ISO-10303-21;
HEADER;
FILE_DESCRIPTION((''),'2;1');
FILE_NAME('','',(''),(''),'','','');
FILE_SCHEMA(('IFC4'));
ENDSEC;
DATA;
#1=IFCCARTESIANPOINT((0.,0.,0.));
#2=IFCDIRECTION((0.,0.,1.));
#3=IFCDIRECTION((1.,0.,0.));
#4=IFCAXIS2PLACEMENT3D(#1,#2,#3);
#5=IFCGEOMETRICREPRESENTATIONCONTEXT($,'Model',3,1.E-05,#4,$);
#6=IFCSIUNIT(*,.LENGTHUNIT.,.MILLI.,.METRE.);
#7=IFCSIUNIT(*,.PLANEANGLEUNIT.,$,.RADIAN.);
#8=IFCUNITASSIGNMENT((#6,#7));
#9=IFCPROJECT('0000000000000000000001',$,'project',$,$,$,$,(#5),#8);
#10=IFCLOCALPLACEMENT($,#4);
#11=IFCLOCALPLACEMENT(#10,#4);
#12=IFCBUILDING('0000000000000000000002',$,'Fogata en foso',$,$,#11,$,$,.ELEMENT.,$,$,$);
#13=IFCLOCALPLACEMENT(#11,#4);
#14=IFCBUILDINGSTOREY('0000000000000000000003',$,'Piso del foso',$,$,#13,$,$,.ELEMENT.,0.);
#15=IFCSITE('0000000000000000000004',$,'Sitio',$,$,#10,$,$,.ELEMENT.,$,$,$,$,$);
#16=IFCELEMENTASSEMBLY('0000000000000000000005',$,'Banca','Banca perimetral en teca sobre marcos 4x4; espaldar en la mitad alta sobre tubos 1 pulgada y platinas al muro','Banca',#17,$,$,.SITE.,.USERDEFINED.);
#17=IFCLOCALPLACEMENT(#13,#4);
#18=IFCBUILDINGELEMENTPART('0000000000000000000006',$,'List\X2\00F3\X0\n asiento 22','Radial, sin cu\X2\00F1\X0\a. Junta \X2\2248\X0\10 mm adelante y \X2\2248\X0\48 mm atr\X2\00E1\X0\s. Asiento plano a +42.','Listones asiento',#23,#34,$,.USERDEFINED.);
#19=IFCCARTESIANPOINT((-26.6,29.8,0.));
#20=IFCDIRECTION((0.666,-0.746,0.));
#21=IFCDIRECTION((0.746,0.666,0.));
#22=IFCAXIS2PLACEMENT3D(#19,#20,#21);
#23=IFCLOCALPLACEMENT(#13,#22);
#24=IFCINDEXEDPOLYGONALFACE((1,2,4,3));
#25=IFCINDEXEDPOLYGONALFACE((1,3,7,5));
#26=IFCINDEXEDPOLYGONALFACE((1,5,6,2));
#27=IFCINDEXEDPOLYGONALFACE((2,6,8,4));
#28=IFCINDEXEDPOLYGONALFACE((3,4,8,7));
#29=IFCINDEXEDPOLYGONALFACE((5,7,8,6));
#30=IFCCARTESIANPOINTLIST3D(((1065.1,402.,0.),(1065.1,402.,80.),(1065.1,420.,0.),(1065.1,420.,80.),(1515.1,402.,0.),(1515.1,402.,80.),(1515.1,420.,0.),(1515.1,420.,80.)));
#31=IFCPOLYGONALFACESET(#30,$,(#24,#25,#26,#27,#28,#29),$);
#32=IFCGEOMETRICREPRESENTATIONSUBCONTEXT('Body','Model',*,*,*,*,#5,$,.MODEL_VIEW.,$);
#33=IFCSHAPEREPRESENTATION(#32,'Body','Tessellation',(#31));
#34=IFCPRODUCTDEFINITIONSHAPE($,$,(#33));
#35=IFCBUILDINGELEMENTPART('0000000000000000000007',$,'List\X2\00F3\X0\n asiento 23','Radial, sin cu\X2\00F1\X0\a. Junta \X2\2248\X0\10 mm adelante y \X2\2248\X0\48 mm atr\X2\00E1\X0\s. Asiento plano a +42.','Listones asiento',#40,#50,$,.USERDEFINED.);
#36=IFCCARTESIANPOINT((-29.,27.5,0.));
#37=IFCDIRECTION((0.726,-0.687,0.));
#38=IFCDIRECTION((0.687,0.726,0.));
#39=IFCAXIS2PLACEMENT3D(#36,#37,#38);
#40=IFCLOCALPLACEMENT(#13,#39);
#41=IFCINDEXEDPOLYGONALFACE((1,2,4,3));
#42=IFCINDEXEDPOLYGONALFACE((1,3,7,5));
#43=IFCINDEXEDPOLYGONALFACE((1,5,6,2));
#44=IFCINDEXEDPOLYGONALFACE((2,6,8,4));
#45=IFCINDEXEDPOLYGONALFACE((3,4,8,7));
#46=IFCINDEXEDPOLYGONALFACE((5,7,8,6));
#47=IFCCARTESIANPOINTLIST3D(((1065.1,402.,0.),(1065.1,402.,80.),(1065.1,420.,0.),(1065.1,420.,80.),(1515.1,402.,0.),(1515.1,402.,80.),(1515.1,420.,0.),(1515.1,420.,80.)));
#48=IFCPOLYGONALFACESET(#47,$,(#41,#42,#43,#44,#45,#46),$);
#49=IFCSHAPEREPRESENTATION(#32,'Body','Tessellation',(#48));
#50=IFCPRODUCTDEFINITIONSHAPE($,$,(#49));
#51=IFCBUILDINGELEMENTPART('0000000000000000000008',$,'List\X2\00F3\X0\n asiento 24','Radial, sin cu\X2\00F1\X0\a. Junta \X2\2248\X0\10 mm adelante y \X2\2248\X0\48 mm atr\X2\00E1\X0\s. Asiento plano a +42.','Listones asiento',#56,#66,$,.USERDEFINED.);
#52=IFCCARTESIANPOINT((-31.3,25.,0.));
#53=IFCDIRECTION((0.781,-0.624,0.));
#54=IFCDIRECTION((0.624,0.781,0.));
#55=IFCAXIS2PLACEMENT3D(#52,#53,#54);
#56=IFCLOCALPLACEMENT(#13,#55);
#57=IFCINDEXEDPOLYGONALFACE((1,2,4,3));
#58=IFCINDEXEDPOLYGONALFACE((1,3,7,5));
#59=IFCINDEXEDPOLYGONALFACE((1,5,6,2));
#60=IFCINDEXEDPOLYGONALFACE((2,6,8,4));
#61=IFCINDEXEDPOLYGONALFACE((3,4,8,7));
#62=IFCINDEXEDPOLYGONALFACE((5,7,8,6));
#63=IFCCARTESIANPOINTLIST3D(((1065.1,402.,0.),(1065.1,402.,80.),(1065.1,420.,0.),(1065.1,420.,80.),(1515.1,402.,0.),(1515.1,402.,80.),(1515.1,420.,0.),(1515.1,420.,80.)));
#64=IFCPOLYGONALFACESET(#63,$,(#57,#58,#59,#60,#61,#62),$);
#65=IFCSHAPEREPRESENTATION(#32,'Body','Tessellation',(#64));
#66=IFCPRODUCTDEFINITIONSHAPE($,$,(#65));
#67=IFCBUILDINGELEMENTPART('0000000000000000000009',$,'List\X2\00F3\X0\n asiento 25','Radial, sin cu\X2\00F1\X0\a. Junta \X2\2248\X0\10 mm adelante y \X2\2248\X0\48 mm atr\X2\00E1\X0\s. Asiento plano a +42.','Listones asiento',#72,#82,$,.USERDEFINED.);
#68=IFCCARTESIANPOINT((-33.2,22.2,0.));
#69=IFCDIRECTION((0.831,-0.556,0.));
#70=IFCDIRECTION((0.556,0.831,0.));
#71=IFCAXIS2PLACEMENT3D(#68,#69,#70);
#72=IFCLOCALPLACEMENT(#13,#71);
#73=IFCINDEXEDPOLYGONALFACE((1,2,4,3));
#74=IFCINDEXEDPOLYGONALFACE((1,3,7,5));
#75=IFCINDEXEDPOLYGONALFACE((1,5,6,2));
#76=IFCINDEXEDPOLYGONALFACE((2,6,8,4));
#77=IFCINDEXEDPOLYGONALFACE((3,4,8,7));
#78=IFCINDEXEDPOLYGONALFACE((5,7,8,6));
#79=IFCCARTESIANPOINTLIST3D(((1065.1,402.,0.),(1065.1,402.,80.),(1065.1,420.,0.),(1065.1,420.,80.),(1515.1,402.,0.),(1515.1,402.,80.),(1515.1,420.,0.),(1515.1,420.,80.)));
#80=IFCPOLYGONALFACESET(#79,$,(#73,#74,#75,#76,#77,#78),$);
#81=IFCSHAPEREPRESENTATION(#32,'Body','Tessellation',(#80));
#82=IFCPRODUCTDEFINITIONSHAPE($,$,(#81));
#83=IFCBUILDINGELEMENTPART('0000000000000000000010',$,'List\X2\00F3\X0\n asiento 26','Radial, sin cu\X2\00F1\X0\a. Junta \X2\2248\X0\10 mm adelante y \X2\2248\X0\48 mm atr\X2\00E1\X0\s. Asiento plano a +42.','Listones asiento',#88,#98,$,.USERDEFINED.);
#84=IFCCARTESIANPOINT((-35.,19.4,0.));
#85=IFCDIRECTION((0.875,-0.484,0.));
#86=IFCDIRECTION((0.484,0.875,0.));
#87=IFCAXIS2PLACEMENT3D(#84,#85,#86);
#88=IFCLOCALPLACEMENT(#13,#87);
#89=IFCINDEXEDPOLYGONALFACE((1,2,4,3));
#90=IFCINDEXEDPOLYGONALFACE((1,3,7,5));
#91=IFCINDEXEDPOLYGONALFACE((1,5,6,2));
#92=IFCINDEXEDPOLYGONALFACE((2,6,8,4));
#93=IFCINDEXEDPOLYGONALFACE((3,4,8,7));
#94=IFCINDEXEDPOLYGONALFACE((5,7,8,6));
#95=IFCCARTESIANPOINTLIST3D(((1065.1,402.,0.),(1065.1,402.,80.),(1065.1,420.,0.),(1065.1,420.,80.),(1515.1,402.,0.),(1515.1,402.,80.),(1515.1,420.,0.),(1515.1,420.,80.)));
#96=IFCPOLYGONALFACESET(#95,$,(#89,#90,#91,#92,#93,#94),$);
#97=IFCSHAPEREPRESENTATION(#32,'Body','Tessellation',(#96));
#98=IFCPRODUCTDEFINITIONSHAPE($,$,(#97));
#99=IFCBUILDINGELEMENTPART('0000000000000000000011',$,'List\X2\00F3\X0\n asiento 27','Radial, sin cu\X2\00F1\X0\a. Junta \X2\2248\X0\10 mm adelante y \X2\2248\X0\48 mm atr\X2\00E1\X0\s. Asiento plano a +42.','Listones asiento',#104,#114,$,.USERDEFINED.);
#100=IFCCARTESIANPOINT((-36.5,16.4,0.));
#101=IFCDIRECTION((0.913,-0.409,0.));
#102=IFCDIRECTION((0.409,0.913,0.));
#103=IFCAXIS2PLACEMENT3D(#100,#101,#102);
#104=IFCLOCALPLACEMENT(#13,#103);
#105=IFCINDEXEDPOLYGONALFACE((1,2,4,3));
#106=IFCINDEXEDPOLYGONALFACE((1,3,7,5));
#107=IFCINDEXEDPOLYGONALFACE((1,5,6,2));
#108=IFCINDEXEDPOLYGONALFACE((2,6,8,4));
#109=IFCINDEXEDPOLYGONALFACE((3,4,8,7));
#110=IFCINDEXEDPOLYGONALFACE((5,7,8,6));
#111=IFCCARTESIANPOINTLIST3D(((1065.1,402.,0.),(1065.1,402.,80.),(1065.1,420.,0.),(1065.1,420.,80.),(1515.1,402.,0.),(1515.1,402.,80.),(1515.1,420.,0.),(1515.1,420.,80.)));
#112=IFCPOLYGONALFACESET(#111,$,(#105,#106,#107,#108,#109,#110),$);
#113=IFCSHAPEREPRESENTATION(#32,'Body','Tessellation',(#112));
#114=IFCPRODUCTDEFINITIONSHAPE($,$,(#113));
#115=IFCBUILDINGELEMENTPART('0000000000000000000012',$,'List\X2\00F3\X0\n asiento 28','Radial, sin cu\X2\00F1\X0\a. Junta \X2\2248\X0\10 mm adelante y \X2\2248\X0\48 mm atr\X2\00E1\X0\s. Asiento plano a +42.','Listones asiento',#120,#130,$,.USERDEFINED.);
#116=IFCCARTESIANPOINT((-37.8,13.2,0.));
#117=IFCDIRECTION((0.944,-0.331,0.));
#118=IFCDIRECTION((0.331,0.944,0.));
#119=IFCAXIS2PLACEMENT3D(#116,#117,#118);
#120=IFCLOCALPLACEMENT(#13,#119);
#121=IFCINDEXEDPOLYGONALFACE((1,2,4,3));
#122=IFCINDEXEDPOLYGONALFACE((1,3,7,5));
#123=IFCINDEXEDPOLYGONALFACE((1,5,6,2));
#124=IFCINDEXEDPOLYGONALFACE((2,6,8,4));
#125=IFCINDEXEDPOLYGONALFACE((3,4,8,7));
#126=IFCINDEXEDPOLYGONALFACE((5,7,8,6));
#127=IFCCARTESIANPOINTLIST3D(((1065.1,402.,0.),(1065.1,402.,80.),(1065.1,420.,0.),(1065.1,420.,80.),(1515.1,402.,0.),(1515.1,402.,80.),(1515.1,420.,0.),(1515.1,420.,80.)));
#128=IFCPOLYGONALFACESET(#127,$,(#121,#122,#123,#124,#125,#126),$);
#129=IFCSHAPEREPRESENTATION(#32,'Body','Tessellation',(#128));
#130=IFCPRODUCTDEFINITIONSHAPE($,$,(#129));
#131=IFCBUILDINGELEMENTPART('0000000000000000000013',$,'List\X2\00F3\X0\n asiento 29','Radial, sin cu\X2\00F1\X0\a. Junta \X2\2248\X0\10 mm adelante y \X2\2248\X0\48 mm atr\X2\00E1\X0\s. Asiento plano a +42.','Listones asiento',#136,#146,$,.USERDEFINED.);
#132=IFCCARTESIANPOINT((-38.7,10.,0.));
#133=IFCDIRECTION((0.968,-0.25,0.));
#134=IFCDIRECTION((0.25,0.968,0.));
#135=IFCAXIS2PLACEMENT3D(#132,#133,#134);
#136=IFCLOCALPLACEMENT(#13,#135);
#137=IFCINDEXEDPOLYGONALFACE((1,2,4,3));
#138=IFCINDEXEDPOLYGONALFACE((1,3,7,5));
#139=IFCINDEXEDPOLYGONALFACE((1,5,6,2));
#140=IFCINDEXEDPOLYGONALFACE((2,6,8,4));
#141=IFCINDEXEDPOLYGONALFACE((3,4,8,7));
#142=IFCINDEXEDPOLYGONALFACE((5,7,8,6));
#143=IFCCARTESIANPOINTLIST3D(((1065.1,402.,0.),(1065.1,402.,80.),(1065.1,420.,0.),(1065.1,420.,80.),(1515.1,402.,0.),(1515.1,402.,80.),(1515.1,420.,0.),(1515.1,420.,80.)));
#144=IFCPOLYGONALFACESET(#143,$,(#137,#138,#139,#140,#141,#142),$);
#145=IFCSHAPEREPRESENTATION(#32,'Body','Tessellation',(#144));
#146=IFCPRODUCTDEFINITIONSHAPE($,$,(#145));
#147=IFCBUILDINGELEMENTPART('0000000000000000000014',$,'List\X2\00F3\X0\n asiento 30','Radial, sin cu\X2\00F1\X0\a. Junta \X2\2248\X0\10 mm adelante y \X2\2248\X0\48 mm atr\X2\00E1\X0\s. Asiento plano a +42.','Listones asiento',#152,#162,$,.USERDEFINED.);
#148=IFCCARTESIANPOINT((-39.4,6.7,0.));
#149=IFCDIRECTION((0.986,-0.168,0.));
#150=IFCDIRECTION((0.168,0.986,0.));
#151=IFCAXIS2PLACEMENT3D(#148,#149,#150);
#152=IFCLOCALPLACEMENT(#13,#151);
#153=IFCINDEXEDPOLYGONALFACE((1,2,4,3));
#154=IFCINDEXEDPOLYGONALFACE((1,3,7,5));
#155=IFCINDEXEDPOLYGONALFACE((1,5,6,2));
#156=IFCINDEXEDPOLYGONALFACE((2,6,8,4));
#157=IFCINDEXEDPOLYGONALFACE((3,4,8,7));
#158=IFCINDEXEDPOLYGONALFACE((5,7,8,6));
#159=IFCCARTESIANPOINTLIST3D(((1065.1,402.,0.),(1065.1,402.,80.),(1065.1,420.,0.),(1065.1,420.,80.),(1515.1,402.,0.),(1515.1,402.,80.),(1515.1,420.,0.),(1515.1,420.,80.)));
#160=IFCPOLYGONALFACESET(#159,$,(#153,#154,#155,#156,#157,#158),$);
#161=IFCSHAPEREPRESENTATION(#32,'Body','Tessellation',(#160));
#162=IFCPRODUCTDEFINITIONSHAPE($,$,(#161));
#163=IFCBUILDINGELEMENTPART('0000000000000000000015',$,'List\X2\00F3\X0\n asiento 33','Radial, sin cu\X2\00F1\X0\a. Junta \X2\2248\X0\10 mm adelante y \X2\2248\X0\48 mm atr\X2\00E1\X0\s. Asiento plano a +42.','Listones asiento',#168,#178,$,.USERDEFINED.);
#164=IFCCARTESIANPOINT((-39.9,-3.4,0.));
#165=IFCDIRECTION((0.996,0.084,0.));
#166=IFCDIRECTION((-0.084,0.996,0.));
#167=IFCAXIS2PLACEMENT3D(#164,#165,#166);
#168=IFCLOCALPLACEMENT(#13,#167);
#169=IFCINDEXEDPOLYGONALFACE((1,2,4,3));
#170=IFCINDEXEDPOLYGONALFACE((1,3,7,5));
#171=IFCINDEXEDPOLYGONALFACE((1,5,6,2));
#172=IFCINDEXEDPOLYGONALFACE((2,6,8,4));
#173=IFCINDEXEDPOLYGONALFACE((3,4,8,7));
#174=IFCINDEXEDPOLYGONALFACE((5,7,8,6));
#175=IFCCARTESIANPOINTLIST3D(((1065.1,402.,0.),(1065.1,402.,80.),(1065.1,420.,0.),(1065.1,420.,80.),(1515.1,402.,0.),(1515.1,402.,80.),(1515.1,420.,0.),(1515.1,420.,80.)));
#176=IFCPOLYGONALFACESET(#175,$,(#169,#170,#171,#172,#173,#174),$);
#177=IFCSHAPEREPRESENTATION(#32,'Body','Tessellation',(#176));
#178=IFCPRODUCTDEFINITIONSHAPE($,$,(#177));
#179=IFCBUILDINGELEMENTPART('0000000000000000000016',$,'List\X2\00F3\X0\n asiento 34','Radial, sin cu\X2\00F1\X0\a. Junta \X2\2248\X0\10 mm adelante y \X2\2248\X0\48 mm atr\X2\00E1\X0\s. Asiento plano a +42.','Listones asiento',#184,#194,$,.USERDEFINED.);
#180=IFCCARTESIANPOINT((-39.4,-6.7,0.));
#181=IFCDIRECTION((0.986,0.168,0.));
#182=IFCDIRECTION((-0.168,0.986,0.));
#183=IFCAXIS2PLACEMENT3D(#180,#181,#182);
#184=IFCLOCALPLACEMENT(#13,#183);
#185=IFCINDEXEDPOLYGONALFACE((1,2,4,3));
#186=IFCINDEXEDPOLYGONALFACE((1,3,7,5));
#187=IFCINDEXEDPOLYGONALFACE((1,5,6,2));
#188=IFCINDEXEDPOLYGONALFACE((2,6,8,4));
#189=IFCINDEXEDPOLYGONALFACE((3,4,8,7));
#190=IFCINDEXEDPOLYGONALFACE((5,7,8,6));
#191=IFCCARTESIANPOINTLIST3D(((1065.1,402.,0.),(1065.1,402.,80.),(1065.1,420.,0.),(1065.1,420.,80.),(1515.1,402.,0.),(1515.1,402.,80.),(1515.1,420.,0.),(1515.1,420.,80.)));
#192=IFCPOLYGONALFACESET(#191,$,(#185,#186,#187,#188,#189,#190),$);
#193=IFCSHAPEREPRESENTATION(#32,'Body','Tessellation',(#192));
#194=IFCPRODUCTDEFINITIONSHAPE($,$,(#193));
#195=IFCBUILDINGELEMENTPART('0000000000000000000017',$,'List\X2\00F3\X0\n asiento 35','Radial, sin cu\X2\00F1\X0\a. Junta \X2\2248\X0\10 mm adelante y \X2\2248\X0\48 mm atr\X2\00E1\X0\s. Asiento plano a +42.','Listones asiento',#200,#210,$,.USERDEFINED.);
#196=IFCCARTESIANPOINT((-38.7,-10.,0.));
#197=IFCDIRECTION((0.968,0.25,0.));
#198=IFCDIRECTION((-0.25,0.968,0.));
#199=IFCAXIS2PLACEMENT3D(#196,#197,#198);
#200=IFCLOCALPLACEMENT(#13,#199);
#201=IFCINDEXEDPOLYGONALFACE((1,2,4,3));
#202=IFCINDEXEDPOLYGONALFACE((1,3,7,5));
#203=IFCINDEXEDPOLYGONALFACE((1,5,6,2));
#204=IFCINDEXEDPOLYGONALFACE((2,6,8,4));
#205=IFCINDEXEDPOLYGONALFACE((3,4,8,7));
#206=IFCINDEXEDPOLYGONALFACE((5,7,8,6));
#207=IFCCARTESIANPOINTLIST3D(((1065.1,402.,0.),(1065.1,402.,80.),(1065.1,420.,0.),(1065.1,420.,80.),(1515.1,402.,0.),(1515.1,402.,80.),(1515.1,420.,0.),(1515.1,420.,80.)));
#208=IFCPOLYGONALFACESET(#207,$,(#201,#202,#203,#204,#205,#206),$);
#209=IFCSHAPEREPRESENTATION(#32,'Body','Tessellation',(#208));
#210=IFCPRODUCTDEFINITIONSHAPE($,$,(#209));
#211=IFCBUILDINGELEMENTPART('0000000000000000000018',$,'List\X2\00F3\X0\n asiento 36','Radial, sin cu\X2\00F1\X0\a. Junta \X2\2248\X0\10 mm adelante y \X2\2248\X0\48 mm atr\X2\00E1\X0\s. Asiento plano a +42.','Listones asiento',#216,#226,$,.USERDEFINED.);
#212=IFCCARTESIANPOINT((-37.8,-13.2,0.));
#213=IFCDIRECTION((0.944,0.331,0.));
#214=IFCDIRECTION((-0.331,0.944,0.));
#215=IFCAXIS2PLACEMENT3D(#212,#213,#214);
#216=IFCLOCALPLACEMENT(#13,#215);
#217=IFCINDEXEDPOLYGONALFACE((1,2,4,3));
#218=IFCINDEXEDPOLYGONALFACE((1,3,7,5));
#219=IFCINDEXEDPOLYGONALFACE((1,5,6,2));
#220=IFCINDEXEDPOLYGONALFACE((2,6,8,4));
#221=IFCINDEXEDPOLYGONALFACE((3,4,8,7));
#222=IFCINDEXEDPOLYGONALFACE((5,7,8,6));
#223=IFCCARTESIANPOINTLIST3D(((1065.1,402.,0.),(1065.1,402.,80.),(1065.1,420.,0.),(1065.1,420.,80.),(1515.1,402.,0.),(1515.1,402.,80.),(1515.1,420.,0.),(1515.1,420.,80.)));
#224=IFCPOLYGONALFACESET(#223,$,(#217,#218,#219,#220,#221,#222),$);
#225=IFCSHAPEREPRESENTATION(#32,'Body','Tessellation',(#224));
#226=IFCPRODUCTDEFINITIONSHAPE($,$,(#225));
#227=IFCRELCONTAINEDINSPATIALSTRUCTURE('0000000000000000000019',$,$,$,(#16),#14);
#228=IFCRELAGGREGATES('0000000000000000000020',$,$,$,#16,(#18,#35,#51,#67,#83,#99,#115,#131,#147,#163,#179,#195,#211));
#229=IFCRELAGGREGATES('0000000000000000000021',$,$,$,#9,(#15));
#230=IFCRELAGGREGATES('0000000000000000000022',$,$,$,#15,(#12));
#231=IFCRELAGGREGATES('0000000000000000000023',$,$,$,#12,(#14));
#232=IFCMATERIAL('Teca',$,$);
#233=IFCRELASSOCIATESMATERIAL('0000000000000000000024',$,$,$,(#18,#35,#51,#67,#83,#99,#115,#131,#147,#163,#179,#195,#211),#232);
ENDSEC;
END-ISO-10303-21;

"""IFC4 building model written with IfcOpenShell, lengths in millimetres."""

from ifc_helpers import new_model, si_unit, frame, origin_with_axes, place, context, subcontext, project, spatial, polyline, outline, extrude, material, element, aggregate, save


model = new_model("IFC4")

# Units and contexts
model_context = context("Model", 3, precision=1e-05, world=origin_with_axes())
body_context = subcontext(model_context, "Body", "Model", "MODEL_VIEW")
ifc_project = project(units=[si_unit("LENGTHUNIT", "METRE", prefix="MILLI"), si_unit("PLANEANGLEUNIT", "RADIAN")], contexts=[model_context])

# Site, building, storey
site_placement = place(None, origin_with_axes())
site = spatial("IfcSite", under=ifc_project, at=site_placement, Name="Sitio", CompositionType="ELEMENT")
building_placement = place(site_placement, origin_with_axes())
building = spatial("IfcBuilding", under=site, at=building_placement, Name="Fogata en foso", CompositionType="ELEMENT")
storey_placement = place(building_placement, origin_with_axes())
storey = spatial("IfcBuildingStorey", under=building, at=storey_placement, Name="Piso del foso", CompositionType="ELEMENT", Elevation=0.0)

# Element assembly, building element parts
assembly_1_placement = place(storey_placement, origin_with_axes())
assembly_1 = element("IfcElementAssembly", 1, at=assembly_1_placement, inside=storey, Name="Banca", Description="Banca perimetral en teca sobre marcos 4x4; espaldar en la mitad alta sobre tubos 1 pulgada y platinas al muro", ObjectType="Banca", AssemblyPlace="SITE", PredefinedType="USERDEFINED")
ifc_material_1 = material(Name="Teca")
building_element_part_1_placement = place(storey_placement, frame((-26.6, 29.8, 0.0), z_axis=(0.666, -0.746, 0.0), x_axis=(0.746, 0.666, 0.0)))
building_element_part_1 = element("IfcBuildingElementPart", 2, at=building_element_part_1_placement, material=ifc_material_1, Name="Listón asiento 22", Description="Radial, sin cuña. Junta ≈10 mm adelante y ≈48 mm atrás. Asiento plano a +42.", ObjectType="Listones asiento", PredefinedType="USERDEFINED", context=body_context, shape_type="SweptSolid", body=[
    extrude(outline(polyline([(1065.1, 402.0), (1515.1, 402.0), (1515.1, 420.0), (1065.1, 420.0), (1065.1, 402.0)])), origin_with_axes(), (0.0, 0.0, 1.0), 80.0),
])
building_element_part_2_placement = place(storey_placement, frame((-29.0, 27.5, 0.0), z_axis=(0.726, -0.687, 0.0), x_axis=(0.687, 0.726, 0.0)))
building_element_part_2 = element("IfcBuildingElementPart", 3, at=building_element_part_2_placement, material=ifc_material_1, Name="Listón asiento 23", Description="Radial, sin cuña. Junta ≈10 mm adelante y ≈48 mm atrás. Asiento plano a +42.", ObjectType="Listones asiento", PredefinedType="USERDEFINED", context=body_context, shape_type="SweptSolid", body=[
    extrude(outline(polyline([(1065.1, 402.0), (1515.1, 402.0), (1515.1, 420.0), (1065.1, 420.0), (1065.1, 402.0)])), origin_with_axes(), (0.0, 0.0, 1.0), 80.0),
])
building_element_part_3_placement = place(storey_placement, frame((-31.3, 25.0, 0.0), z_axis=(0.781, -0.624, 0.0), x_axis=(0.624, 0.781, 0.0)))
building_element_part_3 = element("IfcBuildingElementPart", 4, at=building_element_part_3_placement, material=ifc_material_1, Name="Listón asiento 24", Description="Radial, sin cuña. Junta ≈10 mm adelante y ≈48 mm atrás. Asiento plano a +42.", ObjectType="Listones asiento", PredefinedType="USERDEFINED", context=body_context, shape_type="SweptSolid", body=[
    extrude(outline(polyline([(1065.1, 402.0), (1515.1, 402.0), (1515.1, 420.0), (1065.1, 420.0), (1065.1, 402.0)])), origin_with_axes(), (0.0, 0.0, 1.0), 80.0),
])
building_element_part_4_placement = place(storey_placement, frame((-33.2, 22.2, 0.0), z_axis=(0.831, -0.556, 0.0), x_axis=(0.556, 0.831, 0.0)))
building_element_part_4 = element("IfcBuildingElementPart", 5, at=building_element_part_4_placement, material=ifc_material_1, Name="Listón asiento 25", Description="Radial, sin cuña. Junta ≈10 mm adelante y ≈48 mm atrás. Asiento plano a +42.", ObjectType="Listones asiento", PredefinedType="USERDEFINED", context=body_context, shape_type="SweptSolid", body=[
    extrude(outline(polyline([(1065.1, 402.0), (1515.1, 402.0), (1515.1, 420.0), (1065.1, 420.0), (1065.1, 402.0)])), origin_with_axes(), (0.0, 0.0, 1.0), 80.0),
])
building_element_part_5_placement = place(storey_placement, frame((-35.0, 19.4, 0.0), z_axis=(0.875, -0.484, 0.0), x_axis=(0.484, 0.875, 0.0)))
building_element_part_5 = element("IfcBuildingElementPart", 6, at=building_element_part_5_placement, material=ifc_material_1, Name="Listón asiento 26", Description="Radial, sin cuña. Junta ≈10 mm adelante y ≈48 mm atrás. Asiento plano a +42.", ObjectType="Listones asiento", PredefinedType="USERDEFINED", context=body_context, shape_type="SweptSolid", body=[
    extrude(outline(polyline([(1065.1, 402.0), (1515.1, 402.0), (1515.1, 420.0), (1065.1, 420.0), (1065.1, 402.0)])), origin_with_axes(), (0.0, 0.0, 1.0), 80.0),
])
building_element_part_6_placement = place(storey_placement, frame((-36.5, 16.4, 0.0), z_axis=(0.913, -0.409, 0.0), x_axis=(0.409, 0.913, 0.0)))
building_element_part_6 = element("IfcBuildingElementPart", 7, at=building_element_part_6_placement, material=ifc_material_1, Name="Listón asiento 27", Description="Radial, sin cuña. Junta ≈10 mm adelante y ≈48 mm atrás. Asiento plano a +42.", ObjectType="Listones asiento", PredefinedType="USERDEFINED", context=body_context, shape_type="SweptSolid", body=[
    extrude(outline(polyline([(1065.1, 402.0), (1515.1, 402.0), (1515.1, 420.0), (1065.1, 420.0), (1065.1, 402.0)])), origin_with_axes(), (0.0, 0.0, 1.0), 80.0),
])
building_element_part_7_placement = place(storey_placement, frame((-37.8, 13.2, 0.0), z_axis=(0.944, -0.331, 0.0), x_axis=(0.331, 0.944, 0.0)))
building_element_part_7 = element("IfcBuildingElementPart", 8, at=building_element_part_7_placement, material=ifc_material_1, Name="Listón asiento 28", Description="Radial, sin cuña. Junta ≈10 mm adelante y ≈48 mm atrás. Asiento plano a +42.", ObjectType="Listones asiento", PredefinedType="USERDEFINED", context=body_context, shape_type="SweptSolid", body=[
    extrude(outline(polyline([(1065.1, 402.0), (1515.1, 402.0), (1515.1, 420.0), (1065.1, 420.0), (1065.1, 402.0)])), origin_with_axes(), (0.0, 0.0, 1.0), 80.0),
])
building_element_part_8_placement = place(storey_placement, frame((-38.7, 10.0, 0.0), z_axis=(0.968, -0.25, 0.0), x_axis=(0.25, 0.968, 0.0)))
building_element_part_8 = element("IfcBuildingElementPart", 9, at=building_element_part_8_placement, material=ifc_material_1, Name="Listón asiento 29", Description="Radial, sin cuña. Junta ≈10 mm adelante y ≈48 mm atrás. Asiento plano a +42.", ObjectType="Listones asiento", PredefinedType="USERDEFINED", context=body_context, shape_type="SweptSolid", body=[
    extrude(outline(polyline([(1065.1, 402.0), (1515.1, 402.0), (1515.1, 420.0), (1065.1, 420.0), (1065.1, 402.0)])), origin_with_axes(), (0.0, 0.0, 1.0), 80.0),
])
building_element_part_9_placement = place(storey_placement, frame((-39.4, 6.7, 0.0), z_axis=(0.986, -0.168, 0.0), x_axis=(0.168, 0.986, 0.0)))
building_element_part_9 = element("IfcBuildingElementPart", 10, at=building_element_part_9_placement, material=ifc_material_1, Name="Listón asiento 30", Description="Radial, sin cuña. Junta ≈10 mm adelante y ≈48 mm atrás. Asiento plano a +42.", ObjectType="Listones asiento", PredefinedType="USERDEFINED", context=body_context, shape_type="SweptSolid", body=[
    extrude(outline(polyline([(1065.1, 402.0), (1515.1, 402.0), (1515.1, 420.0), (1065.1, 420.0), (1065.1, 402.0)])), origin_with_axes(), (0.0, 0.0, 1.0), 80.0),
])
building_element_part_10_placement = place(storey_placement, frame((-39.9, -3.4, 0.0), z_axis=(0.996, 0.084, 0.0), x_axis=(-0.084, 0.996, 0.0)))
building_element_part_10 = element("IfcBuildingElementPart", 11, at=building_element_part_10_placement, material=ifc_material_1, Name="Listón asiento 33", Description="Radial, sin cuña. Junta ≈10 mm adelante y ≈48 mm atrás. Asiento plano a +42.", ObjectType="Listones asiento", PredefinedType="USERDEFINED", context=body_context, shape_type="SweptSolid", body=[
    extrude(outline(polyline([(1065.1, 402.0), (1515.1, 402.0), (1515.1, 420.0), (1065.1, 420.0), (1065.1, 402.0)])), origin_with_axes(), (0.0, 0.0, 1.0), 80.0),
])
building_element_part_11_placement = place(storey_placement, frame((-39.4, -6.7, 0.0), z_axis=(0.986, 0.168, 0.0), x_axis=(-0.168, 0.986, 0.0)))
building_element_part_11 = element("IfcBuildingElementPart", 12, at=building_element_part_11_placement, material=ifc_material_1, Name="Listón asiento 34", Description="Radial, sin cuña. Junta ≈10 mm adelante y ≈48 mm atrás. Asiento plano a +42.", ObjectType="Listones asiento", PredefinedType="USERDEFINED", context=body_context, shape_type="SweptSolid", body=[
    extrude(outline(polyline([(1065.1, 402.0), (1515.1, 402.0), (1515.1, 420.0), (1065.1, 420.0), (1065.1, 402.0)])), origin_with_axes(), (0.0, 0.0, 1.0), 80.0),
])
building_element_part_12_placement = place(storey_placement, frame((-38.7, -10.0, 0.0), z_axis=(0.968, 0.25, 0.0), x_axis=(-0.25, 0.968, 0.0)))
building_element_part_12 = element("IfcBuildingElementPart", 13, at=building_element_part_12_placement, material=ifc_material_1, Name="Listón asiento 35", Description="Radial, sin cuña. Junta ≈10 mm adelante y ≈48 mm atrás. Asiento plano a +42.", ObjectType="Listones asiento", PredefinedType="USERDEFINED", context=body_context, shape_type="SweptSolid", body=[
    extrude(outline(polyline([(1065.1, 402.0), (1515.1, 402.0), (1515.1, 420.0), (1065.1, 420.0), (1065.1, 402.0)])), origin_with_axes(), (0.0, 0.0, 1.0), 80.0),
])
building_element_part_13_placement = place(storey_placement, frame((-37.8, -13.2, 0.0), z_axis=(0.944, 0.331, 0.0), x_axis=(-0.331, 0.944, 0.0)))
building_element_part_13 = element("IfcBuildingElementPart", 14, at=building_element_part_13_placement, material=ifc_material_1, Name="Listón asiento 36", Description="Radial, sin cuña. Junta ≈10 mm adelante y ≈48 mm atrás. Asiento plano a +42.", ObjectType="Listones asiento", PredefinedType="USERDEFINED", context=body_context, shape_type="SweptSolid", body=[
    extrude(outline(polyline([(1065.1, 402.0), (1515.1, 402.0), (1515.1, 420.0), (1065.1, 420.0), (1065.1, 402.0)])), origin_with_axes(), (0.0, 0.0, 1.0), 80.0),
])
aggregate(assembly_1, [building_element_part_1, building_element_part_2, building_element_part_3, building_element_part_4, building_element_part_5, building_element_part_6, building_element_part_7, building_element_part_8, building_element_part_9, building_element_part_10, building_element_part_11, building_element_part_12, building_element_part_13])

save(model, "model.ifc")
